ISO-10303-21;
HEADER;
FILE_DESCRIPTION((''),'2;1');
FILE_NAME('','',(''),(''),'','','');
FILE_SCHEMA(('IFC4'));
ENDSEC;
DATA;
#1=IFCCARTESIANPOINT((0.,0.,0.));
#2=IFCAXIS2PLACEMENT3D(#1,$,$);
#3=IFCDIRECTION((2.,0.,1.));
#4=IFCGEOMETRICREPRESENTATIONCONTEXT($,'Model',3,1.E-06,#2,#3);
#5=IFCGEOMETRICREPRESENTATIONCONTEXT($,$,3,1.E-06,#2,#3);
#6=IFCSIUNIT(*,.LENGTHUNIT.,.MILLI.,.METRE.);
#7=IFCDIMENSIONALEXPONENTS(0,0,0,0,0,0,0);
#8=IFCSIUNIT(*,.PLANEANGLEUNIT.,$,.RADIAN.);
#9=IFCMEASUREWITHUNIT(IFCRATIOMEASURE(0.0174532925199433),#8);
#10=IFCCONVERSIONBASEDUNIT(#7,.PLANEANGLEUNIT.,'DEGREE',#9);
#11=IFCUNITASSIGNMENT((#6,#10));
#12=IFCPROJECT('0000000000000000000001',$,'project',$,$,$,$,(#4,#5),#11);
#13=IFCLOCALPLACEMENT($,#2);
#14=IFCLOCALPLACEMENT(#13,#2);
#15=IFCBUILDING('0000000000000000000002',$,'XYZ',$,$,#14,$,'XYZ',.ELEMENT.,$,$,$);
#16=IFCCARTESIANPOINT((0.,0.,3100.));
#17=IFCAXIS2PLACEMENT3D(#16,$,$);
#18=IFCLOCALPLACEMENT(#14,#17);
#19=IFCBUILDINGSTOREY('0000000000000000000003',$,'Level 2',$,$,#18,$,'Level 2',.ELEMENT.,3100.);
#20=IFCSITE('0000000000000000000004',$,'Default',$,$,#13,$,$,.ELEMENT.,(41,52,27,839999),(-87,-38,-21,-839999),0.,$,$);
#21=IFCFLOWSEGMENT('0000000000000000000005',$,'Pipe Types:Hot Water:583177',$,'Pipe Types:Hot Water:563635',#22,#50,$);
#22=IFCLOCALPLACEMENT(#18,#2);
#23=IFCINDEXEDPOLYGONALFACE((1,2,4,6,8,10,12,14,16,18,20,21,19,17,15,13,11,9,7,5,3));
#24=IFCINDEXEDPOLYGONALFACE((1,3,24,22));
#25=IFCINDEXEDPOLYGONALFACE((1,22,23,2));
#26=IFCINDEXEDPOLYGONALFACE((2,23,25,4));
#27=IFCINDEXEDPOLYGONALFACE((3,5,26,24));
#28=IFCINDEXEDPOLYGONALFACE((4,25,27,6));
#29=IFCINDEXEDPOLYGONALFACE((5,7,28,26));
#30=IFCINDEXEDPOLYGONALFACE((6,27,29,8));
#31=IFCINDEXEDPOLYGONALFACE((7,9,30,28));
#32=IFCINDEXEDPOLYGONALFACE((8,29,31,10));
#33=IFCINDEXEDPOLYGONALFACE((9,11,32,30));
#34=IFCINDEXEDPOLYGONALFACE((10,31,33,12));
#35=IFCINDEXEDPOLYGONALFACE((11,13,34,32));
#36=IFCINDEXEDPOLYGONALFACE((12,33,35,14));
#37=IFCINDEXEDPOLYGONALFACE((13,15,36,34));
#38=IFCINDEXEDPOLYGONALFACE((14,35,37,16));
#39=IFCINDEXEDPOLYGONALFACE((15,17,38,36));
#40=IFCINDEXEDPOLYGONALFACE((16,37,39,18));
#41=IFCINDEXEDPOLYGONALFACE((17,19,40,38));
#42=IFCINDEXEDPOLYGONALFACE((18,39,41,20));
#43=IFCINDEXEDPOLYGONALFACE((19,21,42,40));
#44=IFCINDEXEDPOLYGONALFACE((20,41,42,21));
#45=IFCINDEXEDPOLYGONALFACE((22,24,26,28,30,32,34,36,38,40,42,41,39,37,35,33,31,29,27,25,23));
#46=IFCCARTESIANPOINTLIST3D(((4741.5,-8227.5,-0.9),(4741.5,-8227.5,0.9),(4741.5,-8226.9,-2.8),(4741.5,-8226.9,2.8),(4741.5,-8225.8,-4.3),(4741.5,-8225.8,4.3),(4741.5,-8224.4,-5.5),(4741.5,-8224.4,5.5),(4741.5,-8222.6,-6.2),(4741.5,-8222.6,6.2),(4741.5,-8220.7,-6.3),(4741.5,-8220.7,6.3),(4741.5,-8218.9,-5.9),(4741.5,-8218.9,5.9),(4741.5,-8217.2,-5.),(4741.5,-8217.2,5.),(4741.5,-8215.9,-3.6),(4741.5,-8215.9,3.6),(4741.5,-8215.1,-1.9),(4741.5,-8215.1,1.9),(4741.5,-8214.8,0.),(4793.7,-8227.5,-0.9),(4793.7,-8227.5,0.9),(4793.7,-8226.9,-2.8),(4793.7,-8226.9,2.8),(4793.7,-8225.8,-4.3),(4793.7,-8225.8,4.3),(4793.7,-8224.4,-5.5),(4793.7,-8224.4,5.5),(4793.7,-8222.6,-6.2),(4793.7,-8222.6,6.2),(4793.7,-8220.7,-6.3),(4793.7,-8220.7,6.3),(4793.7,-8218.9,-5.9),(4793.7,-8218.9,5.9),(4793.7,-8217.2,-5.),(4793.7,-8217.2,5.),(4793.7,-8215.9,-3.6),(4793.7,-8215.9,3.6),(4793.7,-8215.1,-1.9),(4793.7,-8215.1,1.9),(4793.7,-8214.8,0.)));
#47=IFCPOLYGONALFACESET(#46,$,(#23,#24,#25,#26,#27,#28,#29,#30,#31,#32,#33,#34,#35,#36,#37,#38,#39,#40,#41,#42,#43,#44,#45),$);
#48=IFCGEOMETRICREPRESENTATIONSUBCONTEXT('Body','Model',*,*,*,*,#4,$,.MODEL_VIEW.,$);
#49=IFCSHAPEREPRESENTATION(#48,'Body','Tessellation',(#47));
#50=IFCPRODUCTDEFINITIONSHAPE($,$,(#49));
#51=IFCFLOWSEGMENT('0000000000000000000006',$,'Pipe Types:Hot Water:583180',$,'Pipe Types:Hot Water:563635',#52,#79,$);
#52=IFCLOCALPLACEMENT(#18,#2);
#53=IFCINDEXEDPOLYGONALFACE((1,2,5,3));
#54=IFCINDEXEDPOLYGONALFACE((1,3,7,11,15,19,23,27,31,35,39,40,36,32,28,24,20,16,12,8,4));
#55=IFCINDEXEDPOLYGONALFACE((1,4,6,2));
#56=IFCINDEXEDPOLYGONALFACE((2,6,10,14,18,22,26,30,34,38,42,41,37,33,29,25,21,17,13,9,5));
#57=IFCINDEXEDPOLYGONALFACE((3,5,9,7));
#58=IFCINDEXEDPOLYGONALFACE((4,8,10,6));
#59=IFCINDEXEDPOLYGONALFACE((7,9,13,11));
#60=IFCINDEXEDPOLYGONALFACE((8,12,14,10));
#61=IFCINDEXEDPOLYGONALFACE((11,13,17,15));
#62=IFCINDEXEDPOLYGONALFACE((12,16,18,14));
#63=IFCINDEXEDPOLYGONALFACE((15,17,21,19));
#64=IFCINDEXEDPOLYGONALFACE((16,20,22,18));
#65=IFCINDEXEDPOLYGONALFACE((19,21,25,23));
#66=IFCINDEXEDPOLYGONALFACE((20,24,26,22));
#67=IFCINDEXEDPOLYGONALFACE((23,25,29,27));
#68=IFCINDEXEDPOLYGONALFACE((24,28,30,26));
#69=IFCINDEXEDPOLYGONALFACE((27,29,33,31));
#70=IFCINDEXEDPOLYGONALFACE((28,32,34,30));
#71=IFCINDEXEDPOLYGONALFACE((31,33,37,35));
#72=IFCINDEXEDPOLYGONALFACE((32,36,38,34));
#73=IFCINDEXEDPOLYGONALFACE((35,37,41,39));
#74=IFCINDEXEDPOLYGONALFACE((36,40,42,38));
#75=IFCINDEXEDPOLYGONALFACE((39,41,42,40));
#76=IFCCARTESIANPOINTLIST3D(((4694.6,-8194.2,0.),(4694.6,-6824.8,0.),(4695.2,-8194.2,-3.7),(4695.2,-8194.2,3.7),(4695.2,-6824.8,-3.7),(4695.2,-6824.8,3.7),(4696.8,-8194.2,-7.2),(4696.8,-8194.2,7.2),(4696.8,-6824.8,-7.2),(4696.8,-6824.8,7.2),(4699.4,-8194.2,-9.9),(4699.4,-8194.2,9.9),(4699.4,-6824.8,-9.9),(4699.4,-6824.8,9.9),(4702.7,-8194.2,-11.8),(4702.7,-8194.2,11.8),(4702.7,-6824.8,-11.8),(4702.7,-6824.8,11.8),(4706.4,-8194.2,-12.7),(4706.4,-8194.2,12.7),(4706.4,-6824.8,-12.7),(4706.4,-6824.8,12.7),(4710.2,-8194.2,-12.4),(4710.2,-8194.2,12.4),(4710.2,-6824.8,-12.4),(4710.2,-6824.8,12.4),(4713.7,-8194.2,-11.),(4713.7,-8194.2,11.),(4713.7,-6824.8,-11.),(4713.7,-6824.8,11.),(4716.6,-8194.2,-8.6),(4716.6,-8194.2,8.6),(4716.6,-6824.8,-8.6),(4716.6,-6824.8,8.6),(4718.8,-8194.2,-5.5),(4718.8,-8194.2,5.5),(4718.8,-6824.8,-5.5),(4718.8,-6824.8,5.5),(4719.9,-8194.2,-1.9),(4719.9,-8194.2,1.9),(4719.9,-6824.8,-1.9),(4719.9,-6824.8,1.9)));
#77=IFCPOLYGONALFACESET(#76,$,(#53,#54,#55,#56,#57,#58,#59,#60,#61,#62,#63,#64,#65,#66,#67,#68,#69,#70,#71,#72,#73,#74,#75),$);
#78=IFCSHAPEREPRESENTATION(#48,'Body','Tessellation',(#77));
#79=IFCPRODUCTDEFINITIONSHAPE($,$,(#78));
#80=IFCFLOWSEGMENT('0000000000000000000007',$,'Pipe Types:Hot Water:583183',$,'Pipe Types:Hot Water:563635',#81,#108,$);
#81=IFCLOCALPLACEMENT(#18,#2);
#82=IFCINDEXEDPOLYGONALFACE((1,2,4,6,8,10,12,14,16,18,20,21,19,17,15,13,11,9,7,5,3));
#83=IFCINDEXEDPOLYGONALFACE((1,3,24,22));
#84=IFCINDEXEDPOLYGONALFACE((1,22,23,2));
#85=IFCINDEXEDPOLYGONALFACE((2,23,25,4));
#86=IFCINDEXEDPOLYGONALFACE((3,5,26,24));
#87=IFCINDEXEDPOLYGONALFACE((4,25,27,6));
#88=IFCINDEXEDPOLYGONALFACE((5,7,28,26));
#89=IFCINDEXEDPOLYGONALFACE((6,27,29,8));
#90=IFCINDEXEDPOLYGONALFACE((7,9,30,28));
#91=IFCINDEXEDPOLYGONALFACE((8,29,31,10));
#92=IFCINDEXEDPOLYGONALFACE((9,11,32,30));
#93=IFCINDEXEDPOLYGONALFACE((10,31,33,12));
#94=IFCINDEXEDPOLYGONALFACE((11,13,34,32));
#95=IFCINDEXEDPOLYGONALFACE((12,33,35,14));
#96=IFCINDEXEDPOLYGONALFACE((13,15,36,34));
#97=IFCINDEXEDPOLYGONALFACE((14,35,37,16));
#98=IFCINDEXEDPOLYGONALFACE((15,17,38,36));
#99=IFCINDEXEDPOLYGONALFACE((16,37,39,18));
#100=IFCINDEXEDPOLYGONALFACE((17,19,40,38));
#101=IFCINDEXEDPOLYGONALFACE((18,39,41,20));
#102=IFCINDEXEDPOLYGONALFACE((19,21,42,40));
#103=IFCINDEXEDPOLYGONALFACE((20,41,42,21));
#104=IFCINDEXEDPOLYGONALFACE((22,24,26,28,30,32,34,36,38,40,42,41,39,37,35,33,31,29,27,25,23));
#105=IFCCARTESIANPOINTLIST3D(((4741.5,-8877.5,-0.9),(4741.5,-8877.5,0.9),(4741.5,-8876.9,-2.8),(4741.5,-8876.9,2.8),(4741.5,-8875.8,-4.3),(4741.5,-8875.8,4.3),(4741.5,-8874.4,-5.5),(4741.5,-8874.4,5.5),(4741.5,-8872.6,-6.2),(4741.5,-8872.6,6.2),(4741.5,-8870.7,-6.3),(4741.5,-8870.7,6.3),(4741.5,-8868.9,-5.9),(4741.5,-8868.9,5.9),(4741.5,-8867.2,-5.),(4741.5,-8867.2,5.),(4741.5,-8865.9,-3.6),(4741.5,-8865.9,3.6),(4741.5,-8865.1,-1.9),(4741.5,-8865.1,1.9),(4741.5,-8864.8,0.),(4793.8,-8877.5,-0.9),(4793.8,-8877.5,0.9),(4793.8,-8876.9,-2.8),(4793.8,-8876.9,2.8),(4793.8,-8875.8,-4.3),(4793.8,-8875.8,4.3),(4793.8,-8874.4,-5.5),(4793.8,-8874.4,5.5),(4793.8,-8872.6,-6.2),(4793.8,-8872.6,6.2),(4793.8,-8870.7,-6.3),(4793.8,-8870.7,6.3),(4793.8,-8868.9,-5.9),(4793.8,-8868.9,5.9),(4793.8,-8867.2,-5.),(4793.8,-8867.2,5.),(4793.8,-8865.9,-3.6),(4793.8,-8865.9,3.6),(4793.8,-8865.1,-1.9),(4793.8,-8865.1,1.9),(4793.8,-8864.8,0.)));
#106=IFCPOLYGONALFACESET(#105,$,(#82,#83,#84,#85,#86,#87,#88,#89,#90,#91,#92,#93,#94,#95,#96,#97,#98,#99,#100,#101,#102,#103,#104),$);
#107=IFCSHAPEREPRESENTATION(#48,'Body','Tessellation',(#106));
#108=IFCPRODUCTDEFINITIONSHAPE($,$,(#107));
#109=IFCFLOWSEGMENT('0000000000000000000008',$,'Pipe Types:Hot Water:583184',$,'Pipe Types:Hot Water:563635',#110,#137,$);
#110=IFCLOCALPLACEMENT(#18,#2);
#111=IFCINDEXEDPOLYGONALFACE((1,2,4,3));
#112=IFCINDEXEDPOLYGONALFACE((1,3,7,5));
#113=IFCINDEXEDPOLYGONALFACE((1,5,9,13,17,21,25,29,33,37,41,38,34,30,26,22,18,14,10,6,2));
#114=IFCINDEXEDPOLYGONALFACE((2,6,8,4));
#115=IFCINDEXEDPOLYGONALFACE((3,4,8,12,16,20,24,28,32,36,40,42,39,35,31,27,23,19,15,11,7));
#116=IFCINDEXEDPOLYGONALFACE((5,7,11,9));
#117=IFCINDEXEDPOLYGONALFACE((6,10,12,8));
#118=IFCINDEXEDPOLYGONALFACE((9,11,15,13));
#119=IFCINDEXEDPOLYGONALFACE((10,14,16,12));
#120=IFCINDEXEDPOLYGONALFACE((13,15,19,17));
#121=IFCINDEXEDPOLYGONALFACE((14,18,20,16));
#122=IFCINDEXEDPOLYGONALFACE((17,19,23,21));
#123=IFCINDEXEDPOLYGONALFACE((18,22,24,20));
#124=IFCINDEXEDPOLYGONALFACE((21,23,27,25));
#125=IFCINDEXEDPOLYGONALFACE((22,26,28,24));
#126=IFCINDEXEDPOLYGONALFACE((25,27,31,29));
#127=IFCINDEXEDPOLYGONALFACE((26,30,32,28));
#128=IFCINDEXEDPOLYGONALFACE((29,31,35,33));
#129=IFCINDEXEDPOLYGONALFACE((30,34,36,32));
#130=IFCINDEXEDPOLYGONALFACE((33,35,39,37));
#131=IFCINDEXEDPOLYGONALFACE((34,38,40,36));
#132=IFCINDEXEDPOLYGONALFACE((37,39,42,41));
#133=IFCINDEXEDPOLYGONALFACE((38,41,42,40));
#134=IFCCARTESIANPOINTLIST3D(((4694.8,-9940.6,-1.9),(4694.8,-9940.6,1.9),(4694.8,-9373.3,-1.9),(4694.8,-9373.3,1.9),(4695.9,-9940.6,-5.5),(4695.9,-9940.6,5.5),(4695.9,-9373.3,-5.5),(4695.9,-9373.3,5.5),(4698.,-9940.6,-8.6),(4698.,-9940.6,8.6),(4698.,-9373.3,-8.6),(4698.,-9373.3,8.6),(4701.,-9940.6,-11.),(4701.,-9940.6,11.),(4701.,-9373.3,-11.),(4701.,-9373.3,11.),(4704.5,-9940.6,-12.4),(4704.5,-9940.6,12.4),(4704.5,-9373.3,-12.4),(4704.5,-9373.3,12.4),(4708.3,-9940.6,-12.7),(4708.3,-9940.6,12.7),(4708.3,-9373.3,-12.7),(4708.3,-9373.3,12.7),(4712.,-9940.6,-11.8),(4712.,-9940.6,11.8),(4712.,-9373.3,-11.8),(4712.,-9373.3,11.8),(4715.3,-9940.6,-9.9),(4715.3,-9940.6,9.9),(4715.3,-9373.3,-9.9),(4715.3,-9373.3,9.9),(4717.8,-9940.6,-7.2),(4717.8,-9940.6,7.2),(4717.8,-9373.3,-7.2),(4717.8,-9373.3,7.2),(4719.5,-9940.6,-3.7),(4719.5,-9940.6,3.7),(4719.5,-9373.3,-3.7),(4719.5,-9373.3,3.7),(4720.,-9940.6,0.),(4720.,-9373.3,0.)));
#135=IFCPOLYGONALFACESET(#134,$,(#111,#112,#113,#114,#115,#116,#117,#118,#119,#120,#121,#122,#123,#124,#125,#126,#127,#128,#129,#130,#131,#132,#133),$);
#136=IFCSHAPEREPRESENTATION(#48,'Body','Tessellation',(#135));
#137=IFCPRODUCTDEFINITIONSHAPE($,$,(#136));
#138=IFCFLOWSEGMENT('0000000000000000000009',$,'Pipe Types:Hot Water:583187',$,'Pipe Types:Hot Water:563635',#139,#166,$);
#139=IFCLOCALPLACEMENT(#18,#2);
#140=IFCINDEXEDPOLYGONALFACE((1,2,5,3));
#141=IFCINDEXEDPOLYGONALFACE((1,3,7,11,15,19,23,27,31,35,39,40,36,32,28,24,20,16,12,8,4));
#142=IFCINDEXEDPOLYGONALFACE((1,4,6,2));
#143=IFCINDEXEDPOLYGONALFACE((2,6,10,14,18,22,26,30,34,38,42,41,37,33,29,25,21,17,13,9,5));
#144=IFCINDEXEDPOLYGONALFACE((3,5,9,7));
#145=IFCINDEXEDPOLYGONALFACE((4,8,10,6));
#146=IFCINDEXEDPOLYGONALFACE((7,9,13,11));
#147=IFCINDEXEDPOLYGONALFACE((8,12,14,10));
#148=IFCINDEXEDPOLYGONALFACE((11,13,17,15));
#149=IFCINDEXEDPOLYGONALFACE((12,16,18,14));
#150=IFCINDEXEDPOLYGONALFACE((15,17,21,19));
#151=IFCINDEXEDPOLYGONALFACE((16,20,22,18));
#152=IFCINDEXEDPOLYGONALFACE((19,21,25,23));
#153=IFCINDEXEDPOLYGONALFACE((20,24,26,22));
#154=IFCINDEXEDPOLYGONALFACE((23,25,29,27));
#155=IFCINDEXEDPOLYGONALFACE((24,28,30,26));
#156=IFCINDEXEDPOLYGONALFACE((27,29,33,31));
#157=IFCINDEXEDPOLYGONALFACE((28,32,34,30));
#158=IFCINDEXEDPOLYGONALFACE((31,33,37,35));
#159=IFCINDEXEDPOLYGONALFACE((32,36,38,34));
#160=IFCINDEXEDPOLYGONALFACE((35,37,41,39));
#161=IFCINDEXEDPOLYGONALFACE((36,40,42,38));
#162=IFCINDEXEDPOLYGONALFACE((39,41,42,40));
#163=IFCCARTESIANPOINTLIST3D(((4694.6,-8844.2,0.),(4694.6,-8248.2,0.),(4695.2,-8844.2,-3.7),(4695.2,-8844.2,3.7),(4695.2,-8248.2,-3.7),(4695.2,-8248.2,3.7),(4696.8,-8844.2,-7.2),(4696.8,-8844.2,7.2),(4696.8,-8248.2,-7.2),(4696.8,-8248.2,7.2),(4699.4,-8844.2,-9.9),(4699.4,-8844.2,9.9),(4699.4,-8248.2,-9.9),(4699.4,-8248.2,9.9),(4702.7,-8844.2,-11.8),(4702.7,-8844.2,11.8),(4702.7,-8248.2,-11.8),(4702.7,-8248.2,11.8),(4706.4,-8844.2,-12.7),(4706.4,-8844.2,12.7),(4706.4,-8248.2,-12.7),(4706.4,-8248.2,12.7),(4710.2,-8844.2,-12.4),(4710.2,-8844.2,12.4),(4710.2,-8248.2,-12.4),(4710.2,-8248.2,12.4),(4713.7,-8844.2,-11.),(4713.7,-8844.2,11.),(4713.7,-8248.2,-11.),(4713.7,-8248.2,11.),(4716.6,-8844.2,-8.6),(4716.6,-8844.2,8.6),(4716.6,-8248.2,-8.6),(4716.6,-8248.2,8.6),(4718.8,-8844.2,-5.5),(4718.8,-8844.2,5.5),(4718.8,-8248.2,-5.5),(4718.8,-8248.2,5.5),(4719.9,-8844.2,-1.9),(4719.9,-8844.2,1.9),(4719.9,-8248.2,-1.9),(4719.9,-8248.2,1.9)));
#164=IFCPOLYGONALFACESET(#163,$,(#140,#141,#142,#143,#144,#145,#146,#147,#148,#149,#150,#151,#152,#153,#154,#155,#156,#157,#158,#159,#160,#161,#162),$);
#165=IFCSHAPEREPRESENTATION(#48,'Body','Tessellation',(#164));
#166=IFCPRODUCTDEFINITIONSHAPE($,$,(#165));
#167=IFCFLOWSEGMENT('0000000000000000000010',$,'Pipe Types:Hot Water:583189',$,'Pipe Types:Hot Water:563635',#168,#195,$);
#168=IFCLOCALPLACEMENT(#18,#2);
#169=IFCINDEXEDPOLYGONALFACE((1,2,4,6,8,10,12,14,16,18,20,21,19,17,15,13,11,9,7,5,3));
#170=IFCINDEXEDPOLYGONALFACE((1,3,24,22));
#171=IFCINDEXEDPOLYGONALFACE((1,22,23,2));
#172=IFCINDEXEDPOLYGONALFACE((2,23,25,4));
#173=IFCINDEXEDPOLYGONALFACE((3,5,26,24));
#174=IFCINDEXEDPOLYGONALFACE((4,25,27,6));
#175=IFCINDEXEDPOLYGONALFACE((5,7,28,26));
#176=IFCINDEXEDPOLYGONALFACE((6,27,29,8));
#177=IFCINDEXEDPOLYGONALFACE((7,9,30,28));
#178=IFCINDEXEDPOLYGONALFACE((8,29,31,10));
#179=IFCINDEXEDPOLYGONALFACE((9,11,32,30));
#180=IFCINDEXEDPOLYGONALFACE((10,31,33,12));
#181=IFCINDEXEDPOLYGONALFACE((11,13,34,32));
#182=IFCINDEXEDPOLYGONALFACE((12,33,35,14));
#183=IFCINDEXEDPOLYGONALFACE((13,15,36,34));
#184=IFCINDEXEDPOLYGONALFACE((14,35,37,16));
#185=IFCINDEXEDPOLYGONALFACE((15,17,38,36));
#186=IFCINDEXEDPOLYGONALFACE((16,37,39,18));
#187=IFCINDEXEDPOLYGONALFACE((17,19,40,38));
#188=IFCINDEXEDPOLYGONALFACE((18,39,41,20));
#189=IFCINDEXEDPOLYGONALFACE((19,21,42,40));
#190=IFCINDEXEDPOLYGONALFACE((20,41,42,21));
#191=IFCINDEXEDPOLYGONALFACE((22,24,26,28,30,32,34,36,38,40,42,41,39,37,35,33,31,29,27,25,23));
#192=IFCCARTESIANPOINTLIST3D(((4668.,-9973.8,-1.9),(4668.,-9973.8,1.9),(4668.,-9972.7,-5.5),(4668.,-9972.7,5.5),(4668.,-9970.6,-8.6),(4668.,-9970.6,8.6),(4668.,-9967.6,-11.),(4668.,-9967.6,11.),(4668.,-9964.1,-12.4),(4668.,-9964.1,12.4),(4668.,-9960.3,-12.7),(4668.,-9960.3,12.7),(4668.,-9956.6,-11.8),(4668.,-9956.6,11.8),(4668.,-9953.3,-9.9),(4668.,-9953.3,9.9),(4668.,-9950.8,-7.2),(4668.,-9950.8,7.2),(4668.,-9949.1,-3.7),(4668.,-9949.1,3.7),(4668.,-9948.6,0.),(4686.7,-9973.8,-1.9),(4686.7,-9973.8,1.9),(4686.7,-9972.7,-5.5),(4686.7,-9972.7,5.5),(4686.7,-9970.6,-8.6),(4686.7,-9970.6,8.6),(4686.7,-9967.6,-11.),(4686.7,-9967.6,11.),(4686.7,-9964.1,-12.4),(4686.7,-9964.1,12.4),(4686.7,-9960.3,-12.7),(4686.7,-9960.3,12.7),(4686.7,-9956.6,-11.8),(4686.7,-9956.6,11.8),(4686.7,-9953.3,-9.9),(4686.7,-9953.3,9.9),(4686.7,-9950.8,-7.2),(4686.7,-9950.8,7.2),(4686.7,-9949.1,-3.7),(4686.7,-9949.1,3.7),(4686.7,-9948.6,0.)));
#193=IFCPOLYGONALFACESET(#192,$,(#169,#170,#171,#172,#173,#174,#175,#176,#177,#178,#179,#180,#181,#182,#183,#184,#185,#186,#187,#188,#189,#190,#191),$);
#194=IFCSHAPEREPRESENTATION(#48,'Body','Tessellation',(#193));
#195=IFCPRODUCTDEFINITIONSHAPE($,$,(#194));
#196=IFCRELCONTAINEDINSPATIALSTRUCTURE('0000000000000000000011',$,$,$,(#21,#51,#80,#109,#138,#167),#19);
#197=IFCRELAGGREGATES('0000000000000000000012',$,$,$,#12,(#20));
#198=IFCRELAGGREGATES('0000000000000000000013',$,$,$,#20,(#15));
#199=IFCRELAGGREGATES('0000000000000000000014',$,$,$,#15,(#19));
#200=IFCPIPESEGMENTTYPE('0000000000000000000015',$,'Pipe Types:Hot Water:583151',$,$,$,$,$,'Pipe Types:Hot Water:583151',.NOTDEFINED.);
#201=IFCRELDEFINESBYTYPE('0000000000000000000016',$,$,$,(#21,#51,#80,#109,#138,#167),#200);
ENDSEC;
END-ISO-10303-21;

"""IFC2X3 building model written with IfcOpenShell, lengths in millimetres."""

from ifc_helpers import new_model, entity, si_unit, converted_unit, direction, frame, frame_2d, origin, origin_2d_with_axis, place, context, subcontext, project, spatial, circle, extrude, type_object, element, save


model = new_model("IFC2X3")

# Units and contexts
model_context = context("Model", 3, precision=1e-06, world=origin(), true_north=direction((2.0, 0.0, 1.0)))
context_of_model = context(None, 3, precision=1e-06, world=origin(), true_north=direction((2.0, 0.0, 1.0)))
body_context = subcontext(model_context, "Body", "Model", "MODEL_VIEW")
ifc_project = project(units=[si_unit("LENGTHUNIT", "METRE", prefix="MILLI"), converted_unit("PLANEANGLEUNIT", "DEGREE", entity("IfcRatioMeasure", 0.0174532925199433), si_unit("PLANEANGLEUNIT", "RADIAN"), dimensions=[0, 0, 0, 0, 0, 0, 0])], contexts=[model_context, context_of_model])

# Site, building, storey
site_placement = place(None, origin())
site = spatial("IfcSite", under=ifc_project, at=site_placement, Name="Default", CompositionType="ELEMENT", RefLatitude=(41, 52, 27, 839999), RefLongitude=(-87, -38, -21, -839999), RefElevation=0.0)
building_placement = place(site_placement, origin())
building = spatial("IfcBuilding", under=site, at=building_placement, Name="XYZ", LongName="XYZ", CompositionType="ELEMENT")
storey_placement = place(building_placement, frame((0.0, 0.0, 3100.0)))
storey = spatial("IfcBuildingStorey", under=building, at=storey_placement, Name="Level 2", LongName="Level 2", CompositionType="ELEMENT", Elevation=3100.0)

# Flow segments
pipe_segment_type_1 = type_object("IfcPipeSegmentType", Name="Pipe Types:Hot Water:583151", ElementType="Pipe Types:Hot Water:583151", PredefinedType="NOTDEFINED")
flow_segment_1_placement = place(storey_placement, origin())
element("IfcFlowSegment", 1, at=flow_segment_1_placement, inside=storey, type_object=pipe_segment_type_1, Name="Pipe Types:Hot Water:583177", ObjectType="Pipe Types:Hot Water:563635", context=body_context, shape_type="SweptSolid", body=[
    extrude(circle(Radius=6.3, at=frame_2d((0.0, 0.0), x_axis=(1.0, 0.0))), frame((4741.5, -8221.2, 0.0), z_axis=(1.0, 0.0, 0.0), x_axis=(0.0, 1.0, 0.0)), (0.0, 0.0, 1.0), 52.3),
])
flow_segment_2_placement = place(storey_placement, origin())
element("IfcFlowSegment", 2, at=flow_segment_2_placement, inside=storey, type_object=pipe_segment_type_1, Name="Pipe Types:Hot Water:583180", ObjectType="Pipe Types:Hot Water:563635", context=body_context, shape_type="SweptSolid", body=[
    extrude(circle(Radius=12.7, at=frame_2d((0.0, 0.0), x_axis=(1.0, 0.0))), frame((4707.3, -8194.2, 0.0), z_axis=(0.0, 1.0, 0.0), x_axis=(-1.0, 0.0, 0.0)), (0.0, 0.0, 1.0), 1369.4),
])
flow_segment_3_placement = place(storey_placement, origin())
element("IfcFlowSegment", 3, at=flow_segment_3_placement, inside=storey, type_object=pipe_segment_type_1, Name="Pipe Types:Hot Water:583183", ObjectType="Pipe Types:Hot Water:563635", context=body_context, shape_type="SweptSolid", body=[
    extrude(circle(Radius=6.3, at=frame_2d((0.0, 0.0), x_axis=(1.0, 0.0))), frame((4741.5, -8871.2, 0.0), z_axis=(1.0, 0.0, 0.0), x_axis=(0.0, 1.0, 0.0)), (0.0, 0.0, 1.0), 52.3),
])
flow_segment_4_placement = place(storey_placement, origin())
element("IfcFlowSegment", 4, at=flow_segment_4_placement, inside=storey, type_object=pipe_segment_type_1, Name="Pipe Types:Hot Water:583184", ObjectType="Pipe Types:Hot Water:563635", context=body_context, shape_type="SweptSolid", body=[
    extrude(circle(Radius=12.7, at=origin_2d_with_axis()), frame((4707.3, -9940.6, 0.0), z_axis=(0.0, 1.0, 0.0), x_axis=(1.0, 0.0, 0.0)), (0.0, 0.0, 1.0), 567.3),
])
flow_segment_5_placement = place(storey_placement, origin())
element("IfcFlowSegment", 5, at=flow_segment_5_placement, inside=storey, type_object=pipe_segment_type_1, Name="Pipe Types:Hot Water:583187", ObjectType="Pipe Types:Hot Water:563635", context=body_context, shape_type="SweptSolid", body=[
    extrude(circle(Radius=12.7, at=frame_2d((0.0, 0.0), x_axis=(1.0, 0.0))), frame((4707.3, -8844.2, 0.0), z_axis=(0.0, 1.0, 0.0), x_axis=(-1.0, 0.0, 0.0)), (0.0, 0.0, 1.0), 596.0),
])
flow_segment_6_placement = place(storey_placement, origin())
element("IfcFlowSegment", 6, at=flow_segment_6_placement, inside=storey, type_object=pipe_segment_type_1, Name="Pipe Types:Hot Water:583189", ObjectType="Pipe Types:Hot Water:563635", context=body_context, shape_type="SweptSolid", body=[
    extrude(circle(Radius=12.7, at=frame_2d((0.0, 0.0), x_axis=(1.0, 0.0))), frame((4668.0, -9961.3, 0.0), z_axis=(1.0, 0.0, 0.0), x_axis=(0.0, 1.0, 0.0)), (0.0, 0.0, 1.0), 18.7),
])

save(model, "model.ifc")
